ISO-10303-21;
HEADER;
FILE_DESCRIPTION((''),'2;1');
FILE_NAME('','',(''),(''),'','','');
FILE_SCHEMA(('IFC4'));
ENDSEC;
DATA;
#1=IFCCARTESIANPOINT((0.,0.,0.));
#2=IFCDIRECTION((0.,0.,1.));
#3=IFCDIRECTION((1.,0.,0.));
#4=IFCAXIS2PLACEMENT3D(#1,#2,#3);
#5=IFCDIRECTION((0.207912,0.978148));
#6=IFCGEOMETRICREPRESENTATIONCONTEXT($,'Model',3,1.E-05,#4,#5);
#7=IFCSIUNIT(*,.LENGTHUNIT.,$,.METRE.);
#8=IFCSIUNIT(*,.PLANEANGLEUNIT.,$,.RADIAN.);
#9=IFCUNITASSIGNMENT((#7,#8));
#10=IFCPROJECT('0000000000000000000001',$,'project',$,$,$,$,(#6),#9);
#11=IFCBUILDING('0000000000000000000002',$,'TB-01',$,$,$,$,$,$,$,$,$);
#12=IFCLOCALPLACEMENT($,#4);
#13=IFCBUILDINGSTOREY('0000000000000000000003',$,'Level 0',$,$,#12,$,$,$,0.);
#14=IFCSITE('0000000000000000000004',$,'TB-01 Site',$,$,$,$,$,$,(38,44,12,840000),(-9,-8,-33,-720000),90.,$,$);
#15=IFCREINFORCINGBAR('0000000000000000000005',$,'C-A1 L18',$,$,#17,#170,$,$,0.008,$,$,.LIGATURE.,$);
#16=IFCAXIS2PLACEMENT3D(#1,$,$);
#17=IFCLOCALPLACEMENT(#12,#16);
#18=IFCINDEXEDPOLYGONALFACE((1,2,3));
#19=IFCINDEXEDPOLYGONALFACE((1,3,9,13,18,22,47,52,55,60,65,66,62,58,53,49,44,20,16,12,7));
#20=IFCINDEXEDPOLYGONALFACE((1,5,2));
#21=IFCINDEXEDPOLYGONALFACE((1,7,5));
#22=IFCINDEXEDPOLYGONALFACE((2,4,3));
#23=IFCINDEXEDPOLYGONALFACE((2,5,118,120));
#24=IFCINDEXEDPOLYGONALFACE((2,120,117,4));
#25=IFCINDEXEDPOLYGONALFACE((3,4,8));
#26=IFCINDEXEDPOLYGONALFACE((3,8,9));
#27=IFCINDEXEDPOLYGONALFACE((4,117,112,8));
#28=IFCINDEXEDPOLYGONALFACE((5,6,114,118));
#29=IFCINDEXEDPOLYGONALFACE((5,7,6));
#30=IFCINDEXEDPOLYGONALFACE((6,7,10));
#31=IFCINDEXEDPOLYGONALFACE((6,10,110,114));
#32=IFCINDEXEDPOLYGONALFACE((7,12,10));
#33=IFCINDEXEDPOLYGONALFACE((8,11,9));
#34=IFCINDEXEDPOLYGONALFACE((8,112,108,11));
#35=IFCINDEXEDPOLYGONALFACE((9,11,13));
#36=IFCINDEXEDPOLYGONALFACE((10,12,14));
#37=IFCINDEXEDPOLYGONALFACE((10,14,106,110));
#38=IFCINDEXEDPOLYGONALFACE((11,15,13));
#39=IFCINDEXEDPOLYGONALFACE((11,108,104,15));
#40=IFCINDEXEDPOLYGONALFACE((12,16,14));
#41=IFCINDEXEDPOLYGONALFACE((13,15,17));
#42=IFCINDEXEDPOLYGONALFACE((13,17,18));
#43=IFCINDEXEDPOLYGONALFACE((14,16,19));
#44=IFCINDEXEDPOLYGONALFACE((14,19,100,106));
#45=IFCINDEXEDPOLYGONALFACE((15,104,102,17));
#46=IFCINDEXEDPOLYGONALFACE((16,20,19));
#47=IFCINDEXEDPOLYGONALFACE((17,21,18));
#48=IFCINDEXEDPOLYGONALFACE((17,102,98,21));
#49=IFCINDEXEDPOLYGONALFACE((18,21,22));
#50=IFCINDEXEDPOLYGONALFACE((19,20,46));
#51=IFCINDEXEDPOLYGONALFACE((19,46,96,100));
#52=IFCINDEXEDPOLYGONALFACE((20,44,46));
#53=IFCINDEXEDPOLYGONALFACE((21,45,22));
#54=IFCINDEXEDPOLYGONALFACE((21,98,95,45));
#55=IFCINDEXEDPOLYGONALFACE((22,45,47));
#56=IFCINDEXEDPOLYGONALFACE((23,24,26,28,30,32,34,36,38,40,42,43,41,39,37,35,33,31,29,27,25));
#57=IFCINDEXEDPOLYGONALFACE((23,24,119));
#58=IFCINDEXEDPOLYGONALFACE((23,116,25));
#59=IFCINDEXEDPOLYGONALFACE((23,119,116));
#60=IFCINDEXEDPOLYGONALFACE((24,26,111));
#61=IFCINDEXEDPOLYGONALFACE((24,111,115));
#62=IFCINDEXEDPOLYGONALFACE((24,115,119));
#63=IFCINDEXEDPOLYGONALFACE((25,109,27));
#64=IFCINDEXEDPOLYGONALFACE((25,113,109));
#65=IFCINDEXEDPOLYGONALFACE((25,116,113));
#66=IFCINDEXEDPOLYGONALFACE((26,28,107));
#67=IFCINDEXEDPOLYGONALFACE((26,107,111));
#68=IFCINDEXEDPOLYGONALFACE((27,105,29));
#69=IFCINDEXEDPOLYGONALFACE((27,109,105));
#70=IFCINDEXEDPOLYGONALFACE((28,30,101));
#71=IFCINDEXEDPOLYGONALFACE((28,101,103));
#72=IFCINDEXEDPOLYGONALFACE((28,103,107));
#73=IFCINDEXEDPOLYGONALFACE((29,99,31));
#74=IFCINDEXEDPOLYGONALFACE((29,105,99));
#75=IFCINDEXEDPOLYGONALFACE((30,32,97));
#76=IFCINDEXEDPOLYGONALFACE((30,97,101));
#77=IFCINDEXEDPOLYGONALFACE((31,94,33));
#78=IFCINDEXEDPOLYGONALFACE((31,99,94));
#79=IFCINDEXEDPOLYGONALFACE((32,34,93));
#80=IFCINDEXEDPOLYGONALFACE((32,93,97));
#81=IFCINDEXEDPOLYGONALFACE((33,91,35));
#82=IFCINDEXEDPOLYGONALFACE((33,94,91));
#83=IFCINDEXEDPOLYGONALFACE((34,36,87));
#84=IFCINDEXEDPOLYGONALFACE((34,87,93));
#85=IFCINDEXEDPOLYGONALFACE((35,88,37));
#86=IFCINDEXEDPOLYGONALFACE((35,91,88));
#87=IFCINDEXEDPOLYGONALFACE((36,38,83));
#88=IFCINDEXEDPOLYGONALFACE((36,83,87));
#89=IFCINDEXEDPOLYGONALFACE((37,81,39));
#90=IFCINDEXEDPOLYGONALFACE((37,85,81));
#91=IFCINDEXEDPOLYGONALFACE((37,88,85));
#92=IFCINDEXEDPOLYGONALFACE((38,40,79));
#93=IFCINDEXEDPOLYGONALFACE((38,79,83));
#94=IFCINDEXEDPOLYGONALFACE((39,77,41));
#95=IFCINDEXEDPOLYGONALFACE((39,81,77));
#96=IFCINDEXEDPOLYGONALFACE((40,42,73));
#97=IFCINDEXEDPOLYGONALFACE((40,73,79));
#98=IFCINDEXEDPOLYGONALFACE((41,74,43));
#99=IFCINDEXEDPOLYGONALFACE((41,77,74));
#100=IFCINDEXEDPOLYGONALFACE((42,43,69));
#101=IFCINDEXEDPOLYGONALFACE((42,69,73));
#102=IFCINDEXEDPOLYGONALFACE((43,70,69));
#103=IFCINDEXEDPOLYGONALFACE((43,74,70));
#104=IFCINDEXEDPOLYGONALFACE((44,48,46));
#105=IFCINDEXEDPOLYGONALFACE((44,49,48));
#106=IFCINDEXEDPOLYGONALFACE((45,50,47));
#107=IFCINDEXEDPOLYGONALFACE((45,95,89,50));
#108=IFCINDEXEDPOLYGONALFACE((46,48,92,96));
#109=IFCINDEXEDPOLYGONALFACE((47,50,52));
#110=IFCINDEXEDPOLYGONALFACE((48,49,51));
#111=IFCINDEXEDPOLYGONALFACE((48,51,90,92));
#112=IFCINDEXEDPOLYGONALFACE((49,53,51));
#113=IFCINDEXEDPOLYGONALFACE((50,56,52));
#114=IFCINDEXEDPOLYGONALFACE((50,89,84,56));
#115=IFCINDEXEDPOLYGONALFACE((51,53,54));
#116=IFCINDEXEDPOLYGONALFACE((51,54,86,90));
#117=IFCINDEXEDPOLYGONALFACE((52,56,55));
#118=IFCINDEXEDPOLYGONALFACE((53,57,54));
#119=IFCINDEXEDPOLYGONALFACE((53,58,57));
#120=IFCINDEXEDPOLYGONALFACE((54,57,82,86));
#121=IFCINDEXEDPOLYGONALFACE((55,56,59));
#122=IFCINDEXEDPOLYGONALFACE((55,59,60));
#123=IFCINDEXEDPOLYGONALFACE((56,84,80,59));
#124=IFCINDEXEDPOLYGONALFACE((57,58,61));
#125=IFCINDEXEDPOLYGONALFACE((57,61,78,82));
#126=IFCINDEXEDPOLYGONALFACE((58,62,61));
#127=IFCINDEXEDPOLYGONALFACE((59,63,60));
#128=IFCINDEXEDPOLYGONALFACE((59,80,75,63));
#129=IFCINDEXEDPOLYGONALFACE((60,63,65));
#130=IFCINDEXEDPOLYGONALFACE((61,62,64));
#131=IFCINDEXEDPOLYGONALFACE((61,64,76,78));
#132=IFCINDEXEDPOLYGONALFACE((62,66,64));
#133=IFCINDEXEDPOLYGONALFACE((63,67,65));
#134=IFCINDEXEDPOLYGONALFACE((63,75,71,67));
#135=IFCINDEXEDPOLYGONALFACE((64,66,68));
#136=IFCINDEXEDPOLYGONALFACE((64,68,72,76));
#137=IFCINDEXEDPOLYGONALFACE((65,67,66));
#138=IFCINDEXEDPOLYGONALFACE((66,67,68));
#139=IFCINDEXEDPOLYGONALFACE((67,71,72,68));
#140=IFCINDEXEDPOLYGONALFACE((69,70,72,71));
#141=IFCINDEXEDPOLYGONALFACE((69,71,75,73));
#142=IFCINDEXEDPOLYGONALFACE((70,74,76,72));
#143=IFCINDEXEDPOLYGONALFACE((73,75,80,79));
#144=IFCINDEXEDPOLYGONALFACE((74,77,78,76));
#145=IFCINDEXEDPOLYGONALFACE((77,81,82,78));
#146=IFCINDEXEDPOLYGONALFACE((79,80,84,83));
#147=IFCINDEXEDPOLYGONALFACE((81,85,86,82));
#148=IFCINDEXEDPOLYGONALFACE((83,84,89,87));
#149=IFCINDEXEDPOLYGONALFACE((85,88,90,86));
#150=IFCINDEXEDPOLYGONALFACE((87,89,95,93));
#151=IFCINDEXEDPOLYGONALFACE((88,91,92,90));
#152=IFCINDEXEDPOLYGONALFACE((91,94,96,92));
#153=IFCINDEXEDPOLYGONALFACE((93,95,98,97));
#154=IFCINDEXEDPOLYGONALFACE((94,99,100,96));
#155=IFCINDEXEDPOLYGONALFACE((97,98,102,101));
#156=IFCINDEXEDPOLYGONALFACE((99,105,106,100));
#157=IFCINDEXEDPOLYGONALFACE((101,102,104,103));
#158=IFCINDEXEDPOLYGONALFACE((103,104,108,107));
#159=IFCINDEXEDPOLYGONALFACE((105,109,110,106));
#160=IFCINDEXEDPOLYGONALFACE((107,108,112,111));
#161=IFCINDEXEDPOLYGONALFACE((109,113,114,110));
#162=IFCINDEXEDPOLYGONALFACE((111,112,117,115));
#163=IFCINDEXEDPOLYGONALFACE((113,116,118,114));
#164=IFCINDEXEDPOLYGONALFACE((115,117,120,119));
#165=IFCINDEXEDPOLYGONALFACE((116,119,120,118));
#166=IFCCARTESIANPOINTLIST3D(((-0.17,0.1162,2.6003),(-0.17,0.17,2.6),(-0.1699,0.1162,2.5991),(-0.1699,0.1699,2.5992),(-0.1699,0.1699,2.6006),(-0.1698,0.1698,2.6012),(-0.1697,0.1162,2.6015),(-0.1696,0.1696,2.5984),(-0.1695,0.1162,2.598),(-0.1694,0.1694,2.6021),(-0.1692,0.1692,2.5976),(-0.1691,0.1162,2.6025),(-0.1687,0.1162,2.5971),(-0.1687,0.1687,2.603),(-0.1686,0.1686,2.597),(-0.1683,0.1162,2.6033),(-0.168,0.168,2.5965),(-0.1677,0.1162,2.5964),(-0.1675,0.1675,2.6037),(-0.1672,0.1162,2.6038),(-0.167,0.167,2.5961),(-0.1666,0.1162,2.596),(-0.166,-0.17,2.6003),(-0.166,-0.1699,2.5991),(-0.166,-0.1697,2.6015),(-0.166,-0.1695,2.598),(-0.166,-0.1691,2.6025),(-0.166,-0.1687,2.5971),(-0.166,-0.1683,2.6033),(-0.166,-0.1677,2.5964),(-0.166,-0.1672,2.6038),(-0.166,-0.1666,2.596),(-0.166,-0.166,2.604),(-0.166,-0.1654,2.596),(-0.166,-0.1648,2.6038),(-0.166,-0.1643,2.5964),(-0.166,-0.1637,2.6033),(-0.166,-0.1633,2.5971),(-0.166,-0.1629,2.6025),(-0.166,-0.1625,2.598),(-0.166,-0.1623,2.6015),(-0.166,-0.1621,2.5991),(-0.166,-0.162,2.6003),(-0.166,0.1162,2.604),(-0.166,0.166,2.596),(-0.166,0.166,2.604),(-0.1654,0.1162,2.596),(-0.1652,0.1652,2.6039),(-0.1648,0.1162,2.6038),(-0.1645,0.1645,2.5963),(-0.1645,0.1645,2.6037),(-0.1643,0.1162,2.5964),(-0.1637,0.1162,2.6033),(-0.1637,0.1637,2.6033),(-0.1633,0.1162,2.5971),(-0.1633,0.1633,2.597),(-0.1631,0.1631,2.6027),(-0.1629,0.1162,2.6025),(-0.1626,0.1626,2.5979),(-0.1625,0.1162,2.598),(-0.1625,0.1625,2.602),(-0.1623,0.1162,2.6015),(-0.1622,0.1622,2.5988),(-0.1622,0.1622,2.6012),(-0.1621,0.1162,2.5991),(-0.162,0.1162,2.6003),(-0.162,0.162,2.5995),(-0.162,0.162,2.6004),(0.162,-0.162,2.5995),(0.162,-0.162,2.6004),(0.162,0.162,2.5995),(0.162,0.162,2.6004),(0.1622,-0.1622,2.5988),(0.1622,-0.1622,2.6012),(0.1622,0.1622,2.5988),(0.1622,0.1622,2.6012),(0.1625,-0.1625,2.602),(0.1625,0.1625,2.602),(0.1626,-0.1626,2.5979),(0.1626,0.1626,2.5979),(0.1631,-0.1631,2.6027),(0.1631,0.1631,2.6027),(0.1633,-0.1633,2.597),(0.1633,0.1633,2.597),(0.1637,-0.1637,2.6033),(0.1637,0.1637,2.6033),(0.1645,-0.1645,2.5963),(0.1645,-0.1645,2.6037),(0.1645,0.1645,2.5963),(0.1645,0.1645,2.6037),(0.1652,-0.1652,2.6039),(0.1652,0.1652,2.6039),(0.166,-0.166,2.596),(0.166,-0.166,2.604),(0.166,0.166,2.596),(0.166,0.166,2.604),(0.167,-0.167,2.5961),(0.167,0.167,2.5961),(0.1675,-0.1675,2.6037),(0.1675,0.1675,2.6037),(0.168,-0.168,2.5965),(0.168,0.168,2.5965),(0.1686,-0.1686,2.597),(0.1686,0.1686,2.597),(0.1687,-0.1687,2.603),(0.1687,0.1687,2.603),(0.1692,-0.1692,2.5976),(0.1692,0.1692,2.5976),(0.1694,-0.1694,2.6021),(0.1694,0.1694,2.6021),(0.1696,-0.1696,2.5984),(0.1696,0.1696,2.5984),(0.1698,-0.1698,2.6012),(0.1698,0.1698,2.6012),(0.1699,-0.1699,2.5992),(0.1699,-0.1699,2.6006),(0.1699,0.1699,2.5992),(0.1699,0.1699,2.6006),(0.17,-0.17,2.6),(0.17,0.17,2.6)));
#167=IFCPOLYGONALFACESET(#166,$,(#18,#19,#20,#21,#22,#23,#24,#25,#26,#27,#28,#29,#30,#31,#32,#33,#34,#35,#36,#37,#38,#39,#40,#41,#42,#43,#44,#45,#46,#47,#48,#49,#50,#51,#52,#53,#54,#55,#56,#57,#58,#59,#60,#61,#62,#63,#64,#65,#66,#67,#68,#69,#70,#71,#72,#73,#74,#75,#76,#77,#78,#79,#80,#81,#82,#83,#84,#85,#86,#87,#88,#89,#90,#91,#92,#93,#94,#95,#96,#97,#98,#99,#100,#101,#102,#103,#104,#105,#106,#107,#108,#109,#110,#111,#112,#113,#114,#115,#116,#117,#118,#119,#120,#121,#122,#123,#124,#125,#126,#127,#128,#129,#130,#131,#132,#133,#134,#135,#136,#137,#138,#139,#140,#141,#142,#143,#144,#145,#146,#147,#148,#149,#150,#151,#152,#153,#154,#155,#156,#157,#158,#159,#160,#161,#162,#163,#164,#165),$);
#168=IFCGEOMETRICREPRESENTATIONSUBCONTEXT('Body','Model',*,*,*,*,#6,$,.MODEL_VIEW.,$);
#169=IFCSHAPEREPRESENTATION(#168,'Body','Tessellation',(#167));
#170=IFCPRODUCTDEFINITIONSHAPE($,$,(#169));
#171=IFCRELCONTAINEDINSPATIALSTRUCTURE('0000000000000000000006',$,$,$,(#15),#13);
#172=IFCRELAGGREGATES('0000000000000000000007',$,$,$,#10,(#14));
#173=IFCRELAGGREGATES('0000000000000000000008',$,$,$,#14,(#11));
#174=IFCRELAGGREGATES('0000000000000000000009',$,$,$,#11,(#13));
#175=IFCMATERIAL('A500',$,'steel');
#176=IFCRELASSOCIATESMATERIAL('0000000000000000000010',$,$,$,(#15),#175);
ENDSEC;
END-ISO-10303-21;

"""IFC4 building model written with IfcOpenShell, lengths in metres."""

from ifc_helpers import new_model, entity, si_unit, direction, origin_with_axes, place, context, subcontext, project, spatial, material, element, save


model = new_model("IFC4")

# Units and contexts
model_context = context("Model", 3, precision=1e-05, world=origin_with_axes(), true_north=direction((0.207912, 0.978148)))
body_context = subcontext(model_context, "Body", "Model", "MODEL_VIEW")
ifc_project = project(units=[si_unit("LENGTHUNIT", "METRE"), si_unit("PLANEANGLEUNIT", "RADIAN")], contexts=[model_context])

# Site, building, storey
site = spatial("IfcSite", under=ifc_project, Name="TB-01 Site", RefLatitude=(38, 44, 12, 840000), RefLongitude=(-9, -8, -33, -720000), RefElevation=90.0)
building = spatial("IfcBuilding", under=site, Name="TB-01")
storey_placement = place(None, origin_with_axes())
storey = spatial("IfcBuildingStorey", under=building, at=storey_placement, Name="Level 0", Elevation=0.0)

# Reinforcing bar
ifc_material_1 = material(Name="A500", Category="steel")
reinforcing_bar_1_placement = place(storey_placement, origin_with_axes())
element("IfcReinforcingBar", 1, at=reinforcing_bar_1_placement, inside=storey, material=ifc_material_1, Name="C-A1 L18", NominalDiameter=0.008, PredefinedType="LIGATURE", context=body_context, shape_type="AdvancedSweptSolid", body=[
    entity("IfcSweptDiskSolid", entity("IfcPolyline", [entity("IfcCartesianPoint", [-0.166, -0.166, 2.6]), entity("IfcCartesianPoint", [0.166, -0.166, 2.6]), entity("IfcCartesianPoint", [0.166, 0.166, 2.6]), entity("IfcCartesianPoint", [-0.166, 0.166, 2.6]), entity("IfcCartesianPoint", [-0.166, 0.1162, 2.6])]), 0.004),
])

save(model, "model.ifc")
